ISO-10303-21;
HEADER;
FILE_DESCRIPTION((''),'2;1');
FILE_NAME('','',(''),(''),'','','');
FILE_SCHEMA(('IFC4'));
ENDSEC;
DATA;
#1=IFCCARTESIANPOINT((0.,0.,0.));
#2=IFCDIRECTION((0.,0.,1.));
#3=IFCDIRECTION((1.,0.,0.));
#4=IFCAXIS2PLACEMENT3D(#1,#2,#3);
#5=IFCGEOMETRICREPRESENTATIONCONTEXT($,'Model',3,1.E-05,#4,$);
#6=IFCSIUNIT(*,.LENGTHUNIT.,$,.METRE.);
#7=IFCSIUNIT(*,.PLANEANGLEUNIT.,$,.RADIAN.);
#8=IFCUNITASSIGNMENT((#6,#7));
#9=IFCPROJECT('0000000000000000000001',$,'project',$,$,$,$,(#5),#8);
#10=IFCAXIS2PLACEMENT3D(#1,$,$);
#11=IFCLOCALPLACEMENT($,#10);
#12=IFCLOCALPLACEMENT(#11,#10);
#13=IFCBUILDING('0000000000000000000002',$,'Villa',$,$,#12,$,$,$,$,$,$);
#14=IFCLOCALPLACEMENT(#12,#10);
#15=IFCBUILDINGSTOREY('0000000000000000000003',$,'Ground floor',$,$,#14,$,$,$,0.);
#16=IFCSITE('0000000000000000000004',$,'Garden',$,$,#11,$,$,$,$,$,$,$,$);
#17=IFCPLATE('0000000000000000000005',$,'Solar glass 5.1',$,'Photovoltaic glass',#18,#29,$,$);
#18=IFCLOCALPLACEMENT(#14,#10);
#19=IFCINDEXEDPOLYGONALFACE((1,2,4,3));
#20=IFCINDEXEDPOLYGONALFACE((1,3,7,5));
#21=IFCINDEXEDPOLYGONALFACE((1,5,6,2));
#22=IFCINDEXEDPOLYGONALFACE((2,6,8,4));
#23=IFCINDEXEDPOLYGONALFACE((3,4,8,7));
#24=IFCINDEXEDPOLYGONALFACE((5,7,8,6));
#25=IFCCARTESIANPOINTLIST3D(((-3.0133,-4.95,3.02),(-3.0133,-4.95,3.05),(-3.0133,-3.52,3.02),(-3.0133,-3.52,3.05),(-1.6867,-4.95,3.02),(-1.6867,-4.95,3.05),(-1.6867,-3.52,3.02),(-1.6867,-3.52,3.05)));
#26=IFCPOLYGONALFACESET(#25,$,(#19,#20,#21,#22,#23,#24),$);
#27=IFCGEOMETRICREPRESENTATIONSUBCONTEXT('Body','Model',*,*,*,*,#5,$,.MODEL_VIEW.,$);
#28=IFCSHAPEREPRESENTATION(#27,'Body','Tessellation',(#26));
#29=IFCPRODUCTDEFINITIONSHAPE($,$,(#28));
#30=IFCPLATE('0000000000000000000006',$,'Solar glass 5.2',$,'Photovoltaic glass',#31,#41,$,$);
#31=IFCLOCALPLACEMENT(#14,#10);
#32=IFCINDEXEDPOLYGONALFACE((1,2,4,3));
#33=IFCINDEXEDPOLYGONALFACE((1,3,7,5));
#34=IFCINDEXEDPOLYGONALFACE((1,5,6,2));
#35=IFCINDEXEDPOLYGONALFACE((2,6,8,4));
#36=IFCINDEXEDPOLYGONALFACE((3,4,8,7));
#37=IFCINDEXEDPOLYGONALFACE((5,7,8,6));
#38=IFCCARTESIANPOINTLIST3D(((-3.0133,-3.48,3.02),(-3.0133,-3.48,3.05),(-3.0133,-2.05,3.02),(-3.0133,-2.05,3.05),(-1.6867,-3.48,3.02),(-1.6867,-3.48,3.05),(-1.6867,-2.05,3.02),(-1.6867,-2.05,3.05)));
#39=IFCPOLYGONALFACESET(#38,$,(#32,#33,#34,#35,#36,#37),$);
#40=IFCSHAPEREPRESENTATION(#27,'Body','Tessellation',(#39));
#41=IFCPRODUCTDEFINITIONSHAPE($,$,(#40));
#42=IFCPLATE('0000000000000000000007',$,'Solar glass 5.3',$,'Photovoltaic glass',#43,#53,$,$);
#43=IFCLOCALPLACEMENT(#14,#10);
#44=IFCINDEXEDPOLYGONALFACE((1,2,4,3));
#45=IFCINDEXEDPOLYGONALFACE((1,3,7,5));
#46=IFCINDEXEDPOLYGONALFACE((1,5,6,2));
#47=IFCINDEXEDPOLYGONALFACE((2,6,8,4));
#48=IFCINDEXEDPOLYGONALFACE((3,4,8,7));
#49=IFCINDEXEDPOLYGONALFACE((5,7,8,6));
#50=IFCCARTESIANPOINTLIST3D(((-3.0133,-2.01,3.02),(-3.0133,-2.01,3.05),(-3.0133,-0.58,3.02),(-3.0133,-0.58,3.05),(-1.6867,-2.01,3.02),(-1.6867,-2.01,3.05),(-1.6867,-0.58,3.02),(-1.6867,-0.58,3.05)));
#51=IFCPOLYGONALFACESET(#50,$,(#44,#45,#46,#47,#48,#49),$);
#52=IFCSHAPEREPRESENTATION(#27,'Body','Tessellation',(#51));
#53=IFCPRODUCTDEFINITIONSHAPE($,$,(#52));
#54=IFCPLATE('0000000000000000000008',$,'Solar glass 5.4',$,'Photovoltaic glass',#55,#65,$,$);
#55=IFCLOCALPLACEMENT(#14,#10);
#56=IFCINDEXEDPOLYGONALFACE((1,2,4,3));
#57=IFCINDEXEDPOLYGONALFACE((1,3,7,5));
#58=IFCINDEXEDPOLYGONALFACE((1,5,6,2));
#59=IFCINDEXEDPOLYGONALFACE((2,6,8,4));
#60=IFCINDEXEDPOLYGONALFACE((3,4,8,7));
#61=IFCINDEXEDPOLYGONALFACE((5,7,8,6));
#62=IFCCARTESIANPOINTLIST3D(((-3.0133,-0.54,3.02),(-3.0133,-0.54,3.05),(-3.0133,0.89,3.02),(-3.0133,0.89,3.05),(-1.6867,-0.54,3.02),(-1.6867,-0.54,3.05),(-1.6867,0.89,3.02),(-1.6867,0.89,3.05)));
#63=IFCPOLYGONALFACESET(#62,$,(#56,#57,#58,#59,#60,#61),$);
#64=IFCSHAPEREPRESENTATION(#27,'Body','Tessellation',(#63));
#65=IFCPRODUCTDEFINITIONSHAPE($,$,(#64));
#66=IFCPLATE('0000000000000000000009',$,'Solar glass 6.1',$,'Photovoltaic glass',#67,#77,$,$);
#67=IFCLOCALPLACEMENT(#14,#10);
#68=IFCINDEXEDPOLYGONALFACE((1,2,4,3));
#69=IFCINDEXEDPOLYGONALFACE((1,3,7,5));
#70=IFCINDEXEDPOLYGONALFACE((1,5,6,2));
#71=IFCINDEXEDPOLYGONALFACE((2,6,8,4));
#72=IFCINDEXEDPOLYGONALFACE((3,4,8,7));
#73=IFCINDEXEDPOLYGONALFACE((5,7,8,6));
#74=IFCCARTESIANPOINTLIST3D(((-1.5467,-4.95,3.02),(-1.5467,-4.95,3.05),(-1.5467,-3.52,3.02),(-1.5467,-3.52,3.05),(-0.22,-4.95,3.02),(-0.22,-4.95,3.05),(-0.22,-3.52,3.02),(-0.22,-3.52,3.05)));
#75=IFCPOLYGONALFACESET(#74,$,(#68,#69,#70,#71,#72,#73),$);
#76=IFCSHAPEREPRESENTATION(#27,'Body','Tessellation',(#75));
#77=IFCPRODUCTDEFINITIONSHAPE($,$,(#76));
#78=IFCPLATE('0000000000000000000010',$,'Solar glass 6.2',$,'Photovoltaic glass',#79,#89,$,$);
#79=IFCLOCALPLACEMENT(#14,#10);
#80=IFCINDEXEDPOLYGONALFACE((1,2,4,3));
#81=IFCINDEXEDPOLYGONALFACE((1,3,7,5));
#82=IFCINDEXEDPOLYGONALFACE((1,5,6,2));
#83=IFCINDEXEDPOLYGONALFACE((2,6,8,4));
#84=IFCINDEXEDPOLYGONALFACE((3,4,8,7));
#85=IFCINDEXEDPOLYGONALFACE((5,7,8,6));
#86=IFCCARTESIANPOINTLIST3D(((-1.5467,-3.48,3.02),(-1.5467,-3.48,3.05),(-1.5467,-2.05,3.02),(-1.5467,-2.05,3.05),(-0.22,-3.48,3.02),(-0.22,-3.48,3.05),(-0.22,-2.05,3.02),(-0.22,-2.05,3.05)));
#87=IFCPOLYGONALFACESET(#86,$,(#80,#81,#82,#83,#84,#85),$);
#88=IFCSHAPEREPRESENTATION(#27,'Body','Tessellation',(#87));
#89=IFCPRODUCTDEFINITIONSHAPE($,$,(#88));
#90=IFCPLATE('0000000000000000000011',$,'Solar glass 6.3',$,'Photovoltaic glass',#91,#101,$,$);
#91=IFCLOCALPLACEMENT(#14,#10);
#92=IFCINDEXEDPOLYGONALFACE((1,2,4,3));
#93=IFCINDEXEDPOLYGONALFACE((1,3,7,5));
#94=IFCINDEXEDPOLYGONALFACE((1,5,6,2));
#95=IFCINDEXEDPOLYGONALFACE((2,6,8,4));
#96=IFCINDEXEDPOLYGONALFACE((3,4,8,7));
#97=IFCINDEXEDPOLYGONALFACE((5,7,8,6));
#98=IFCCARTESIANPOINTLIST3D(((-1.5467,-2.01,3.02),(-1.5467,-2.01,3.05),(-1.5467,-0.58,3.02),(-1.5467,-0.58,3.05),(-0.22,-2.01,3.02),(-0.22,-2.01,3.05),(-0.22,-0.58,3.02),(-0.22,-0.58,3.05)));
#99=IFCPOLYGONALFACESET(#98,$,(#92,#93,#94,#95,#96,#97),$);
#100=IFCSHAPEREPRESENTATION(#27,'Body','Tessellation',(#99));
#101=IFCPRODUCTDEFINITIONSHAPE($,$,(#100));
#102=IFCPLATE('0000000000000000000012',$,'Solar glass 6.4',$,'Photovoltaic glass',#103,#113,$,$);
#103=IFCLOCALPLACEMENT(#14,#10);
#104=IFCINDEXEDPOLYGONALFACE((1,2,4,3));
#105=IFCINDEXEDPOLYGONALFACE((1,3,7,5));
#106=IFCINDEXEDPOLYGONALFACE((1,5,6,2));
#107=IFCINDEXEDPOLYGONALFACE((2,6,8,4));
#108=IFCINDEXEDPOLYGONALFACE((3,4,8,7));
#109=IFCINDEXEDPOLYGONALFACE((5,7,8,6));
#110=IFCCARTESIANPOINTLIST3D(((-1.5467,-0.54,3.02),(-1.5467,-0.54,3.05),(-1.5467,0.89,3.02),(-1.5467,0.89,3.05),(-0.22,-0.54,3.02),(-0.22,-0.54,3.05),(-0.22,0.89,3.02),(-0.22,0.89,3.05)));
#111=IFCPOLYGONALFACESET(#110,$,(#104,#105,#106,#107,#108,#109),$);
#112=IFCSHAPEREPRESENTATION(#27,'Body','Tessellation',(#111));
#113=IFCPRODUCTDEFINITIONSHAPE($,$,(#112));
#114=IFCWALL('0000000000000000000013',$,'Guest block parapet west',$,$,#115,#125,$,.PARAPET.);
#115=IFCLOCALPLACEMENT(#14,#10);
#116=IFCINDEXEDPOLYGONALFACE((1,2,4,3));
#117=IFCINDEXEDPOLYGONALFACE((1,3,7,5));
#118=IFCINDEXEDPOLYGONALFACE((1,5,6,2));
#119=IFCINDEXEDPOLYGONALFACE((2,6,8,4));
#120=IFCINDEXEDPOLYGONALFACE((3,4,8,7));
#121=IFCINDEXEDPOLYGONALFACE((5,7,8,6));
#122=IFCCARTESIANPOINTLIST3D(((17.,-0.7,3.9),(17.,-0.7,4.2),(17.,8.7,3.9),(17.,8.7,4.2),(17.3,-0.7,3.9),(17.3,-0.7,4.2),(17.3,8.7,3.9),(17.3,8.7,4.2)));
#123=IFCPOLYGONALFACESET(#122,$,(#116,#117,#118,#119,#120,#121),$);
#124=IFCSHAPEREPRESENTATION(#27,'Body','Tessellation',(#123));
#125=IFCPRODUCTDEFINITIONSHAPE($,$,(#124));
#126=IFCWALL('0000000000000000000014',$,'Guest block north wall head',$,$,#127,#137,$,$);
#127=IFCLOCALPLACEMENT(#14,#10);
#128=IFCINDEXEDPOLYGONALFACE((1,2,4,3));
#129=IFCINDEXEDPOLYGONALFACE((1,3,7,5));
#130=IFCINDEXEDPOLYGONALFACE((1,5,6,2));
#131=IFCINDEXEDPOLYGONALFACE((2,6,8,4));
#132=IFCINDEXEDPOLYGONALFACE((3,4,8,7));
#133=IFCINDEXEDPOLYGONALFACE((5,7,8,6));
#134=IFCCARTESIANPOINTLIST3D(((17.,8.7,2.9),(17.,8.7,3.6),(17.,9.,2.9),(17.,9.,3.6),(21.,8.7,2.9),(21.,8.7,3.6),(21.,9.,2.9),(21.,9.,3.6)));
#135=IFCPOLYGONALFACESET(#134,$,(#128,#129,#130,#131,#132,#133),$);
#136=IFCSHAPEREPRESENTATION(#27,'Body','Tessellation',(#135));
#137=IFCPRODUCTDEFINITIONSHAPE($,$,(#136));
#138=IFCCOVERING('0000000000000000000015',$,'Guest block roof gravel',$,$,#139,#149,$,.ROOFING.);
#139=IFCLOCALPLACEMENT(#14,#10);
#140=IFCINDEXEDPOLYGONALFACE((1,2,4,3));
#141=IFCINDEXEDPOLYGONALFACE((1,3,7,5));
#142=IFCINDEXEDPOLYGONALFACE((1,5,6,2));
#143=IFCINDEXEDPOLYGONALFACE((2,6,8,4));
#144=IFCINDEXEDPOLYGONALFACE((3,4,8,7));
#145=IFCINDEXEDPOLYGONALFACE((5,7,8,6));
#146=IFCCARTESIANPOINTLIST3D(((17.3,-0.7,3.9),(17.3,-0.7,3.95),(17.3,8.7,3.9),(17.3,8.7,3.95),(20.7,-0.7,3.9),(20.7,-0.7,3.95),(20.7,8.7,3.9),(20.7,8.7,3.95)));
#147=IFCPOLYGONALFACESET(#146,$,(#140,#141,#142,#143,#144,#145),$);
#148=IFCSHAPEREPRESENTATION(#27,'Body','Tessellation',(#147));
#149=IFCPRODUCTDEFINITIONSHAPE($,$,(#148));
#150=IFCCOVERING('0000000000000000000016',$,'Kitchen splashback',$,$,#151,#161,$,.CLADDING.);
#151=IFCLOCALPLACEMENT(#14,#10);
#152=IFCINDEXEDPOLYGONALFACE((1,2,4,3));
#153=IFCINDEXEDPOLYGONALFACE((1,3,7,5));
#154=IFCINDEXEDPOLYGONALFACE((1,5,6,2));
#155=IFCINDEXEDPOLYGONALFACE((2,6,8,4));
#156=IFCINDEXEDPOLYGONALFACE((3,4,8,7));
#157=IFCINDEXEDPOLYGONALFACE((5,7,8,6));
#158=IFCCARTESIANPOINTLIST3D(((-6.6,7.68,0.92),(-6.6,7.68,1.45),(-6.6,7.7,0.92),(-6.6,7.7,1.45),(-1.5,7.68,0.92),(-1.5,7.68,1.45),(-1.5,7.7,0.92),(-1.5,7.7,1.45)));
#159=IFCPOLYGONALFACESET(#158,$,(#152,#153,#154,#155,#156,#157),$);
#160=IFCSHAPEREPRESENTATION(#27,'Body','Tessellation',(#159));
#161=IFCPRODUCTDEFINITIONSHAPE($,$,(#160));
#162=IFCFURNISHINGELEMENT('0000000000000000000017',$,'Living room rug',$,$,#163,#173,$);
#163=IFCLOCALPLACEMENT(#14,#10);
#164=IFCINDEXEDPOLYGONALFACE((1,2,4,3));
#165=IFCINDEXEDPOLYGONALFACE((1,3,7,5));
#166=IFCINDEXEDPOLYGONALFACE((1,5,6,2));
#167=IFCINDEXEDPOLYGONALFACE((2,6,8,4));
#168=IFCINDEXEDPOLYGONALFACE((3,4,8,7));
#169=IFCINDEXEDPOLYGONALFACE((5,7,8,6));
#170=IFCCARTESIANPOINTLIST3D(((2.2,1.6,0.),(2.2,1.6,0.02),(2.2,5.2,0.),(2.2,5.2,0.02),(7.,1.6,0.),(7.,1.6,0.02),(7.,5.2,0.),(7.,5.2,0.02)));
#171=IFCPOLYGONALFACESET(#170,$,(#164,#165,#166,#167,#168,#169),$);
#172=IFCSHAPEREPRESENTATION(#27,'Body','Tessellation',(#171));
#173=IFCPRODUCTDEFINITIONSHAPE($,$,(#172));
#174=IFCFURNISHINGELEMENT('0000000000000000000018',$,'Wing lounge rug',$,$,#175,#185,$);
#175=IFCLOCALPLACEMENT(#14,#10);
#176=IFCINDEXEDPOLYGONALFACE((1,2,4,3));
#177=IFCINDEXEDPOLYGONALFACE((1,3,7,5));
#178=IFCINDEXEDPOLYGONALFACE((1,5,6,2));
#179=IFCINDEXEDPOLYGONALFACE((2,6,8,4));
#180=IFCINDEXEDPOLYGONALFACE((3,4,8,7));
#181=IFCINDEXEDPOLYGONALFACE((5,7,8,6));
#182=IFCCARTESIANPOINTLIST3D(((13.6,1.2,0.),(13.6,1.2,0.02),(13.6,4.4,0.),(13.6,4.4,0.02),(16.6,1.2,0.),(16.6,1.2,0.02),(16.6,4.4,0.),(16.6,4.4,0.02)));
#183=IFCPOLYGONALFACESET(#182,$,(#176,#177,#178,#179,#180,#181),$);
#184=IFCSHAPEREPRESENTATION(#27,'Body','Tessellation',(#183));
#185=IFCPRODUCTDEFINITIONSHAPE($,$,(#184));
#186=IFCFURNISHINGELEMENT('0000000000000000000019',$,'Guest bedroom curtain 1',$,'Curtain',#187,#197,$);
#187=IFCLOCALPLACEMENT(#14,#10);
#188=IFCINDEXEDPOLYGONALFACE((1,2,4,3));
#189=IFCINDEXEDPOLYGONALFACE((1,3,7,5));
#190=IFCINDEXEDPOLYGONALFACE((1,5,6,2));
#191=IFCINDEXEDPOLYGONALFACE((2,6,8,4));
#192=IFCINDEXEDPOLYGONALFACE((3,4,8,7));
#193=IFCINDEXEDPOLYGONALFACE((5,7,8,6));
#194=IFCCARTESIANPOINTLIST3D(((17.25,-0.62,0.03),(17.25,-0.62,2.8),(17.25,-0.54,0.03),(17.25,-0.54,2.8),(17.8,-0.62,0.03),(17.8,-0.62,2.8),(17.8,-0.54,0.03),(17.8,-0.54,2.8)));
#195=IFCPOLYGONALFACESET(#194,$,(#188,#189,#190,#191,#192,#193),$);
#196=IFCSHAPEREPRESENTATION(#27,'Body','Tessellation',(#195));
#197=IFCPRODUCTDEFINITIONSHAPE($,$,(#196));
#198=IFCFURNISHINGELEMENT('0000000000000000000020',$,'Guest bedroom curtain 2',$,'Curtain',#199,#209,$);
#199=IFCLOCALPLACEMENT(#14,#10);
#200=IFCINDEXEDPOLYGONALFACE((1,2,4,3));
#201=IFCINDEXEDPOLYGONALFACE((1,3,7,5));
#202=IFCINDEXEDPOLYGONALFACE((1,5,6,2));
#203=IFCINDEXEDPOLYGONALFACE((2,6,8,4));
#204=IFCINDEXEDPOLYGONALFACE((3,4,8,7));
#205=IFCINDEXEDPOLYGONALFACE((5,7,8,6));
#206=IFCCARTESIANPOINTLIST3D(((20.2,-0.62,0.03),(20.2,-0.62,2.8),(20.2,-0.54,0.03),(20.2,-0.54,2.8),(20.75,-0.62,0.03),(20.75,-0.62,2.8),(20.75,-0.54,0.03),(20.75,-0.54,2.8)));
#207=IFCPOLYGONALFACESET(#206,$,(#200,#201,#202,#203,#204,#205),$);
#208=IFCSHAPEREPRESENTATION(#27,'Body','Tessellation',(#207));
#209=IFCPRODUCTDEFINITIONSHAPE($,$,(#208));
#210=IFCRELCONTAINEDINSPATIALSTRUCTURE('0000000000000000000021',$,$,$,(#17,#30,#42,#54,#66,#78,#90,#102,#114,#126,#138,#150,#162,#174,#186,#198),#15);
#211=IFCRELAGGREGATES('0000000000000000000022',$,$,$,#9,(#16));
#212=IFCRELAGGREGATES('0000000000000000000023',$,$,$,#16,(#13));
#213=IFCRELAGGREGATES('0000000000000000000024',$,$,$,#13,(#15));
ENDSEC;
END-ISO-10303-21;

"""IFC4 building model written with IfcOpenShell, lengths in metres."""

from ifc_helpers import new_model, si_unit, frame, frame_2d, origin, origin_with_axes, place, context, subcontext, project, spatial, rectangle, extrude, element, save


model = new_model("IFC4")

# Units and contexts
model_context = context("Model", 3, precision=1e-05, world=origin_with_axes())
body_context = subcontext(model_context, "Body", "Model", "MODEL_VIEW")
ifc_project = project(units=[si_unit("LENGTHUNIT", "METRE"), si_unit("PLANEANGLEUNIT", "RADIAN")], contexts=[model_context])

# Site, building, storey
site_placement = place(None, origin())
site = spatial("IfcSite", under=ifc_project, at=site_placement, Name="Garden")
building_placement = place(site_placement, origin())
building = spatial("IfcBuilding", under=site, at=building_placement, Name="Villa")
storey_placement = place(building_placement, origin())
storey = spatial("IfcBuildingStorey", under=building, at=storey_placement, Name="Ground floor", Elevation=0.0)

# Plates
plate_1_placement = place(storey_placement, origin())
element("IfcPlate", 1, at=plate_1_placement, inside=storey, Name="Solar glass 5.1", ObjectType="Photovoltaic glass", context=body_context, shape_type="SweptSolid", body=[
    extrude(rectangle(XDim=1.3267, YDim=1.43, at=frame_2d((0.6633, 0.715))), frame((-3.0133, -4.95, 3.02)), (0.0, 0.0, 1.0), 0.03),
])
plate_2_placement = place(storey_placement, origin())
element("IfcPlate", 2, at=plate_2_placement, inside=storey, Name="Solar glass 5.2", ObjectType="Photovoltaic glass", context=body_context, shape_type="SweptSolid", body=[
    extrude(rectangle(XDim=1.3267, YDim=1.43, at=frame_2d((0.6633, 0.715))), frame((-3.0133, -3.48, 3.02)), (0.0, 0.0, 1.0), 0.03),
])
plate_3_placement = place(storey_placement, origin())
element("IfcPlate", 3, at=plate_3_placement, inside=storey, Name="Solar glass 5.3", ObjectType="Photovoltaic glass", context=body_context, shape_type="SweptSolid", body=[
    extrude(rectangle(XDim=1.3267, YDim=1.43, at=frame_2d((0.6633, 0.715))), frame((-3.0133, -2.01, 3.02)), (0.0, 0.0, 1.0), 0.03),
])
plate_4_placement = place(storey_placement, origin())
element("IfcPlate", 4, at=plate_4_placement, inside=storey, Name="Solar glass 5.4", ObjectType="Photovoltaic glass", context=body_context, shape_type="SweptSolid", body=[
    extrude(rectangle(XDim=1.3267, YDim=1.43, at=frame_2d((0.6633, 0.715))), frame((-3.0133, -0.54, 3.02)), (0.0, 0.0, 1.0), 0.03),
])
plate_5_placement = place(storey_placement, origin())
element("IfcPlate", 5, at=plate_5_placement, inside=storey, Name="Solar glass 6.1", ObjectType="Photovoltaic glass", context=body_context, shape_type="SweptSolid", body=[
    extrude(rectangle(XDim=1.3267, YDim=1.43, at=frame_2d((0.6633, 0.715))), frame((-1.5467, -4.95, 3.02)), (0.0, 0.0, 1.0), 0.03),
])
plate_6_placement = place(storey_placement, origin())
element("IfcPlate", 6, at=plate_6_placement, inside=storey, Name="Solar glass 6.2", ObjectType="Photovoltaic glass", context=body_context, shape_type="SweptSolid", body=[
    extrude(rectangle(XDim=1.3267, YDim=1.43, at=frame_2d((0.6633, 0.715))), frame((-1.5467, -3.48, 3.02)), (0.0, 0.0, 1.0), 0.03),
])
plate_7_placement = place(storey_placement, origin())
element("IfcPlate", 7, at=plate_7_placement, inside=storey, Name="Solar glass 6.3", ObjectType="Photovoltaic glass", context=body_context, shape_type="SweptSolid", body=[
    extrude(rectangle(XDim=1.3267, YDim=1.43, at=frame_2d((0.6633, 0.715))), frame((-1.5467, -2.01, 3.02)), (0.0, 0.0, 1.0), 0.03),
])
plate_8_placement = place(storey_placement, origin())
element("IfcPlate", 8, at=plate_8_placement, inside=storey, Name="Solar glass 6.4", ObjectType="Photovoltaic glass", context=body_context, shape_type="SweptSolid", body=[
    extrude(rectangle(XDim=1.3267, YDim=1.43, at=frame_2d((0.6633, 0.715))), frame((-1.5467, -0.54, 3.02)), (0.0, 0.0, 1.0), 0.03),
])

# Walls
wall_1_placement = place(storey_placement, origin())
element("IfcWall", 9, at=wall_1_placement, inside=storey, Name="Guest block parapet west", PredefinedType="PARAPET", context=body_context, shape_type="SweptSolid", body=[
    extrude(rectangle(XDim=0.3, YDim=9.4, at=frame_2d((0.15, 4.7))), frame((17.0, -0.7, 3.9)), (0.0, 0.0, 1.0), 0.3),
])
wall_2_placement = place(storey_placement, origin())
element("IfcWall", 10, at=wall_2_placement, inside=storey, Name="Guest block north wall head", context=body_context, shape_type="SweptSolid", body=[
    extrude(rectangle(XDim=4.0, YDim=0.3, at=frame_2d((2.0, 0.15))), frame((17.0, 8.7, 2.9)), (0.0, 0.0, 1.0), 0.7),
])

# Coverings
covering_1_placement = place(storey_placement, origin())
element("IfcCovering", 11, at=covering_1_placement, inside=storey, Name="Guest block roof gravel", PredefinedType="ROOFING", context=body_context, shape_type="SweptSolid", body=[
    extrude(rectangle(XDim=3.4, YDim=9.4, at=frame_2d((1.7, 4.7))), frame((17.3, -0.7, 3.9)), (0.0, 0.0, 1.0), 0.05),
])
covering_2_placement = place(storey_placement, origin())
element("IfcCovering", 12, at=covering_2_placement, inside=storey, Name="Kitchen splashback", PredefinedType="CLADDING", context=body_context, shape_type="SweptSolid", body=[
    extrude(rectangle(XDim=5.1, YDim=0.02, at=frame_2d((2.55, 0.01))), frame((-6.6, 7.68, 0.92)), (0.0, 0.0, 1.0), 0.53),
])

# Furnishing elements
furnishing_1_placement = place(storey_placement, origin())
element("IfcFurnishingElement", 13, at=furnishing_1_placement, inside=storey, Name="Living room rug", context=body_context, shape_type="SweptSolid", body=[
    extrude(rectangle(XDim=4.8, YDim=3.6, at=frame_2d((2.4, 1.8))), frame((2.2, 1.6, 0.0)), (0.0, 0.0, 1.0), 0.02),
])
furnishing_2_placement = place(storey_placement, origin())
element("IfcFurnishingElement", 14, at=furnishing_2_placement, inside=storey, Name="Wing lounge rug", context=body_context, shape_type="SweptSolid", body=[
    extrude(rectangle(XDim=3.0, YDim=3.2, at=frame_2d((1.5, 1.6))), frame((13.6, 1.2, 0.0)), (0.0, 0.0, 1.0), 0.02),
])
furnishing_3_placement = place(storey_placement, origin())
element("IfcFurnishingElement", 15, at=furnishing_3_placement, inside=storey, Name="Guest bedroom curtain 1", ObjectType="Curtain", context=body_context, shape_type="SweptSolid", body=[
    extrude(rectangle(XDim=0.55, YDim=0.08, at=frame_2d((0.275, 0.04))), frame((17.25, -0.62, 0.03)), (0.0, 0.0, 1.0), 2.77),
])
furnishing_4_placement = place(storey_placement, origin())
element("IfcFurnishingElement", 16, at=furnishing_4_placement, inside=storey, Name="Guest bedroom curtain 2", ObjectType="Curtain", context=body_context, shape_type="SweptSolid", body=[
    extrude(rectangle(XDim=0.55, YDim=0.08, at=frame_2d((0.275, 0.04))), frame((20.2, -0.62, 0.03)), (0.0, 0.0, 1.0), 2.77),
])

save(model, "model.ifc")
